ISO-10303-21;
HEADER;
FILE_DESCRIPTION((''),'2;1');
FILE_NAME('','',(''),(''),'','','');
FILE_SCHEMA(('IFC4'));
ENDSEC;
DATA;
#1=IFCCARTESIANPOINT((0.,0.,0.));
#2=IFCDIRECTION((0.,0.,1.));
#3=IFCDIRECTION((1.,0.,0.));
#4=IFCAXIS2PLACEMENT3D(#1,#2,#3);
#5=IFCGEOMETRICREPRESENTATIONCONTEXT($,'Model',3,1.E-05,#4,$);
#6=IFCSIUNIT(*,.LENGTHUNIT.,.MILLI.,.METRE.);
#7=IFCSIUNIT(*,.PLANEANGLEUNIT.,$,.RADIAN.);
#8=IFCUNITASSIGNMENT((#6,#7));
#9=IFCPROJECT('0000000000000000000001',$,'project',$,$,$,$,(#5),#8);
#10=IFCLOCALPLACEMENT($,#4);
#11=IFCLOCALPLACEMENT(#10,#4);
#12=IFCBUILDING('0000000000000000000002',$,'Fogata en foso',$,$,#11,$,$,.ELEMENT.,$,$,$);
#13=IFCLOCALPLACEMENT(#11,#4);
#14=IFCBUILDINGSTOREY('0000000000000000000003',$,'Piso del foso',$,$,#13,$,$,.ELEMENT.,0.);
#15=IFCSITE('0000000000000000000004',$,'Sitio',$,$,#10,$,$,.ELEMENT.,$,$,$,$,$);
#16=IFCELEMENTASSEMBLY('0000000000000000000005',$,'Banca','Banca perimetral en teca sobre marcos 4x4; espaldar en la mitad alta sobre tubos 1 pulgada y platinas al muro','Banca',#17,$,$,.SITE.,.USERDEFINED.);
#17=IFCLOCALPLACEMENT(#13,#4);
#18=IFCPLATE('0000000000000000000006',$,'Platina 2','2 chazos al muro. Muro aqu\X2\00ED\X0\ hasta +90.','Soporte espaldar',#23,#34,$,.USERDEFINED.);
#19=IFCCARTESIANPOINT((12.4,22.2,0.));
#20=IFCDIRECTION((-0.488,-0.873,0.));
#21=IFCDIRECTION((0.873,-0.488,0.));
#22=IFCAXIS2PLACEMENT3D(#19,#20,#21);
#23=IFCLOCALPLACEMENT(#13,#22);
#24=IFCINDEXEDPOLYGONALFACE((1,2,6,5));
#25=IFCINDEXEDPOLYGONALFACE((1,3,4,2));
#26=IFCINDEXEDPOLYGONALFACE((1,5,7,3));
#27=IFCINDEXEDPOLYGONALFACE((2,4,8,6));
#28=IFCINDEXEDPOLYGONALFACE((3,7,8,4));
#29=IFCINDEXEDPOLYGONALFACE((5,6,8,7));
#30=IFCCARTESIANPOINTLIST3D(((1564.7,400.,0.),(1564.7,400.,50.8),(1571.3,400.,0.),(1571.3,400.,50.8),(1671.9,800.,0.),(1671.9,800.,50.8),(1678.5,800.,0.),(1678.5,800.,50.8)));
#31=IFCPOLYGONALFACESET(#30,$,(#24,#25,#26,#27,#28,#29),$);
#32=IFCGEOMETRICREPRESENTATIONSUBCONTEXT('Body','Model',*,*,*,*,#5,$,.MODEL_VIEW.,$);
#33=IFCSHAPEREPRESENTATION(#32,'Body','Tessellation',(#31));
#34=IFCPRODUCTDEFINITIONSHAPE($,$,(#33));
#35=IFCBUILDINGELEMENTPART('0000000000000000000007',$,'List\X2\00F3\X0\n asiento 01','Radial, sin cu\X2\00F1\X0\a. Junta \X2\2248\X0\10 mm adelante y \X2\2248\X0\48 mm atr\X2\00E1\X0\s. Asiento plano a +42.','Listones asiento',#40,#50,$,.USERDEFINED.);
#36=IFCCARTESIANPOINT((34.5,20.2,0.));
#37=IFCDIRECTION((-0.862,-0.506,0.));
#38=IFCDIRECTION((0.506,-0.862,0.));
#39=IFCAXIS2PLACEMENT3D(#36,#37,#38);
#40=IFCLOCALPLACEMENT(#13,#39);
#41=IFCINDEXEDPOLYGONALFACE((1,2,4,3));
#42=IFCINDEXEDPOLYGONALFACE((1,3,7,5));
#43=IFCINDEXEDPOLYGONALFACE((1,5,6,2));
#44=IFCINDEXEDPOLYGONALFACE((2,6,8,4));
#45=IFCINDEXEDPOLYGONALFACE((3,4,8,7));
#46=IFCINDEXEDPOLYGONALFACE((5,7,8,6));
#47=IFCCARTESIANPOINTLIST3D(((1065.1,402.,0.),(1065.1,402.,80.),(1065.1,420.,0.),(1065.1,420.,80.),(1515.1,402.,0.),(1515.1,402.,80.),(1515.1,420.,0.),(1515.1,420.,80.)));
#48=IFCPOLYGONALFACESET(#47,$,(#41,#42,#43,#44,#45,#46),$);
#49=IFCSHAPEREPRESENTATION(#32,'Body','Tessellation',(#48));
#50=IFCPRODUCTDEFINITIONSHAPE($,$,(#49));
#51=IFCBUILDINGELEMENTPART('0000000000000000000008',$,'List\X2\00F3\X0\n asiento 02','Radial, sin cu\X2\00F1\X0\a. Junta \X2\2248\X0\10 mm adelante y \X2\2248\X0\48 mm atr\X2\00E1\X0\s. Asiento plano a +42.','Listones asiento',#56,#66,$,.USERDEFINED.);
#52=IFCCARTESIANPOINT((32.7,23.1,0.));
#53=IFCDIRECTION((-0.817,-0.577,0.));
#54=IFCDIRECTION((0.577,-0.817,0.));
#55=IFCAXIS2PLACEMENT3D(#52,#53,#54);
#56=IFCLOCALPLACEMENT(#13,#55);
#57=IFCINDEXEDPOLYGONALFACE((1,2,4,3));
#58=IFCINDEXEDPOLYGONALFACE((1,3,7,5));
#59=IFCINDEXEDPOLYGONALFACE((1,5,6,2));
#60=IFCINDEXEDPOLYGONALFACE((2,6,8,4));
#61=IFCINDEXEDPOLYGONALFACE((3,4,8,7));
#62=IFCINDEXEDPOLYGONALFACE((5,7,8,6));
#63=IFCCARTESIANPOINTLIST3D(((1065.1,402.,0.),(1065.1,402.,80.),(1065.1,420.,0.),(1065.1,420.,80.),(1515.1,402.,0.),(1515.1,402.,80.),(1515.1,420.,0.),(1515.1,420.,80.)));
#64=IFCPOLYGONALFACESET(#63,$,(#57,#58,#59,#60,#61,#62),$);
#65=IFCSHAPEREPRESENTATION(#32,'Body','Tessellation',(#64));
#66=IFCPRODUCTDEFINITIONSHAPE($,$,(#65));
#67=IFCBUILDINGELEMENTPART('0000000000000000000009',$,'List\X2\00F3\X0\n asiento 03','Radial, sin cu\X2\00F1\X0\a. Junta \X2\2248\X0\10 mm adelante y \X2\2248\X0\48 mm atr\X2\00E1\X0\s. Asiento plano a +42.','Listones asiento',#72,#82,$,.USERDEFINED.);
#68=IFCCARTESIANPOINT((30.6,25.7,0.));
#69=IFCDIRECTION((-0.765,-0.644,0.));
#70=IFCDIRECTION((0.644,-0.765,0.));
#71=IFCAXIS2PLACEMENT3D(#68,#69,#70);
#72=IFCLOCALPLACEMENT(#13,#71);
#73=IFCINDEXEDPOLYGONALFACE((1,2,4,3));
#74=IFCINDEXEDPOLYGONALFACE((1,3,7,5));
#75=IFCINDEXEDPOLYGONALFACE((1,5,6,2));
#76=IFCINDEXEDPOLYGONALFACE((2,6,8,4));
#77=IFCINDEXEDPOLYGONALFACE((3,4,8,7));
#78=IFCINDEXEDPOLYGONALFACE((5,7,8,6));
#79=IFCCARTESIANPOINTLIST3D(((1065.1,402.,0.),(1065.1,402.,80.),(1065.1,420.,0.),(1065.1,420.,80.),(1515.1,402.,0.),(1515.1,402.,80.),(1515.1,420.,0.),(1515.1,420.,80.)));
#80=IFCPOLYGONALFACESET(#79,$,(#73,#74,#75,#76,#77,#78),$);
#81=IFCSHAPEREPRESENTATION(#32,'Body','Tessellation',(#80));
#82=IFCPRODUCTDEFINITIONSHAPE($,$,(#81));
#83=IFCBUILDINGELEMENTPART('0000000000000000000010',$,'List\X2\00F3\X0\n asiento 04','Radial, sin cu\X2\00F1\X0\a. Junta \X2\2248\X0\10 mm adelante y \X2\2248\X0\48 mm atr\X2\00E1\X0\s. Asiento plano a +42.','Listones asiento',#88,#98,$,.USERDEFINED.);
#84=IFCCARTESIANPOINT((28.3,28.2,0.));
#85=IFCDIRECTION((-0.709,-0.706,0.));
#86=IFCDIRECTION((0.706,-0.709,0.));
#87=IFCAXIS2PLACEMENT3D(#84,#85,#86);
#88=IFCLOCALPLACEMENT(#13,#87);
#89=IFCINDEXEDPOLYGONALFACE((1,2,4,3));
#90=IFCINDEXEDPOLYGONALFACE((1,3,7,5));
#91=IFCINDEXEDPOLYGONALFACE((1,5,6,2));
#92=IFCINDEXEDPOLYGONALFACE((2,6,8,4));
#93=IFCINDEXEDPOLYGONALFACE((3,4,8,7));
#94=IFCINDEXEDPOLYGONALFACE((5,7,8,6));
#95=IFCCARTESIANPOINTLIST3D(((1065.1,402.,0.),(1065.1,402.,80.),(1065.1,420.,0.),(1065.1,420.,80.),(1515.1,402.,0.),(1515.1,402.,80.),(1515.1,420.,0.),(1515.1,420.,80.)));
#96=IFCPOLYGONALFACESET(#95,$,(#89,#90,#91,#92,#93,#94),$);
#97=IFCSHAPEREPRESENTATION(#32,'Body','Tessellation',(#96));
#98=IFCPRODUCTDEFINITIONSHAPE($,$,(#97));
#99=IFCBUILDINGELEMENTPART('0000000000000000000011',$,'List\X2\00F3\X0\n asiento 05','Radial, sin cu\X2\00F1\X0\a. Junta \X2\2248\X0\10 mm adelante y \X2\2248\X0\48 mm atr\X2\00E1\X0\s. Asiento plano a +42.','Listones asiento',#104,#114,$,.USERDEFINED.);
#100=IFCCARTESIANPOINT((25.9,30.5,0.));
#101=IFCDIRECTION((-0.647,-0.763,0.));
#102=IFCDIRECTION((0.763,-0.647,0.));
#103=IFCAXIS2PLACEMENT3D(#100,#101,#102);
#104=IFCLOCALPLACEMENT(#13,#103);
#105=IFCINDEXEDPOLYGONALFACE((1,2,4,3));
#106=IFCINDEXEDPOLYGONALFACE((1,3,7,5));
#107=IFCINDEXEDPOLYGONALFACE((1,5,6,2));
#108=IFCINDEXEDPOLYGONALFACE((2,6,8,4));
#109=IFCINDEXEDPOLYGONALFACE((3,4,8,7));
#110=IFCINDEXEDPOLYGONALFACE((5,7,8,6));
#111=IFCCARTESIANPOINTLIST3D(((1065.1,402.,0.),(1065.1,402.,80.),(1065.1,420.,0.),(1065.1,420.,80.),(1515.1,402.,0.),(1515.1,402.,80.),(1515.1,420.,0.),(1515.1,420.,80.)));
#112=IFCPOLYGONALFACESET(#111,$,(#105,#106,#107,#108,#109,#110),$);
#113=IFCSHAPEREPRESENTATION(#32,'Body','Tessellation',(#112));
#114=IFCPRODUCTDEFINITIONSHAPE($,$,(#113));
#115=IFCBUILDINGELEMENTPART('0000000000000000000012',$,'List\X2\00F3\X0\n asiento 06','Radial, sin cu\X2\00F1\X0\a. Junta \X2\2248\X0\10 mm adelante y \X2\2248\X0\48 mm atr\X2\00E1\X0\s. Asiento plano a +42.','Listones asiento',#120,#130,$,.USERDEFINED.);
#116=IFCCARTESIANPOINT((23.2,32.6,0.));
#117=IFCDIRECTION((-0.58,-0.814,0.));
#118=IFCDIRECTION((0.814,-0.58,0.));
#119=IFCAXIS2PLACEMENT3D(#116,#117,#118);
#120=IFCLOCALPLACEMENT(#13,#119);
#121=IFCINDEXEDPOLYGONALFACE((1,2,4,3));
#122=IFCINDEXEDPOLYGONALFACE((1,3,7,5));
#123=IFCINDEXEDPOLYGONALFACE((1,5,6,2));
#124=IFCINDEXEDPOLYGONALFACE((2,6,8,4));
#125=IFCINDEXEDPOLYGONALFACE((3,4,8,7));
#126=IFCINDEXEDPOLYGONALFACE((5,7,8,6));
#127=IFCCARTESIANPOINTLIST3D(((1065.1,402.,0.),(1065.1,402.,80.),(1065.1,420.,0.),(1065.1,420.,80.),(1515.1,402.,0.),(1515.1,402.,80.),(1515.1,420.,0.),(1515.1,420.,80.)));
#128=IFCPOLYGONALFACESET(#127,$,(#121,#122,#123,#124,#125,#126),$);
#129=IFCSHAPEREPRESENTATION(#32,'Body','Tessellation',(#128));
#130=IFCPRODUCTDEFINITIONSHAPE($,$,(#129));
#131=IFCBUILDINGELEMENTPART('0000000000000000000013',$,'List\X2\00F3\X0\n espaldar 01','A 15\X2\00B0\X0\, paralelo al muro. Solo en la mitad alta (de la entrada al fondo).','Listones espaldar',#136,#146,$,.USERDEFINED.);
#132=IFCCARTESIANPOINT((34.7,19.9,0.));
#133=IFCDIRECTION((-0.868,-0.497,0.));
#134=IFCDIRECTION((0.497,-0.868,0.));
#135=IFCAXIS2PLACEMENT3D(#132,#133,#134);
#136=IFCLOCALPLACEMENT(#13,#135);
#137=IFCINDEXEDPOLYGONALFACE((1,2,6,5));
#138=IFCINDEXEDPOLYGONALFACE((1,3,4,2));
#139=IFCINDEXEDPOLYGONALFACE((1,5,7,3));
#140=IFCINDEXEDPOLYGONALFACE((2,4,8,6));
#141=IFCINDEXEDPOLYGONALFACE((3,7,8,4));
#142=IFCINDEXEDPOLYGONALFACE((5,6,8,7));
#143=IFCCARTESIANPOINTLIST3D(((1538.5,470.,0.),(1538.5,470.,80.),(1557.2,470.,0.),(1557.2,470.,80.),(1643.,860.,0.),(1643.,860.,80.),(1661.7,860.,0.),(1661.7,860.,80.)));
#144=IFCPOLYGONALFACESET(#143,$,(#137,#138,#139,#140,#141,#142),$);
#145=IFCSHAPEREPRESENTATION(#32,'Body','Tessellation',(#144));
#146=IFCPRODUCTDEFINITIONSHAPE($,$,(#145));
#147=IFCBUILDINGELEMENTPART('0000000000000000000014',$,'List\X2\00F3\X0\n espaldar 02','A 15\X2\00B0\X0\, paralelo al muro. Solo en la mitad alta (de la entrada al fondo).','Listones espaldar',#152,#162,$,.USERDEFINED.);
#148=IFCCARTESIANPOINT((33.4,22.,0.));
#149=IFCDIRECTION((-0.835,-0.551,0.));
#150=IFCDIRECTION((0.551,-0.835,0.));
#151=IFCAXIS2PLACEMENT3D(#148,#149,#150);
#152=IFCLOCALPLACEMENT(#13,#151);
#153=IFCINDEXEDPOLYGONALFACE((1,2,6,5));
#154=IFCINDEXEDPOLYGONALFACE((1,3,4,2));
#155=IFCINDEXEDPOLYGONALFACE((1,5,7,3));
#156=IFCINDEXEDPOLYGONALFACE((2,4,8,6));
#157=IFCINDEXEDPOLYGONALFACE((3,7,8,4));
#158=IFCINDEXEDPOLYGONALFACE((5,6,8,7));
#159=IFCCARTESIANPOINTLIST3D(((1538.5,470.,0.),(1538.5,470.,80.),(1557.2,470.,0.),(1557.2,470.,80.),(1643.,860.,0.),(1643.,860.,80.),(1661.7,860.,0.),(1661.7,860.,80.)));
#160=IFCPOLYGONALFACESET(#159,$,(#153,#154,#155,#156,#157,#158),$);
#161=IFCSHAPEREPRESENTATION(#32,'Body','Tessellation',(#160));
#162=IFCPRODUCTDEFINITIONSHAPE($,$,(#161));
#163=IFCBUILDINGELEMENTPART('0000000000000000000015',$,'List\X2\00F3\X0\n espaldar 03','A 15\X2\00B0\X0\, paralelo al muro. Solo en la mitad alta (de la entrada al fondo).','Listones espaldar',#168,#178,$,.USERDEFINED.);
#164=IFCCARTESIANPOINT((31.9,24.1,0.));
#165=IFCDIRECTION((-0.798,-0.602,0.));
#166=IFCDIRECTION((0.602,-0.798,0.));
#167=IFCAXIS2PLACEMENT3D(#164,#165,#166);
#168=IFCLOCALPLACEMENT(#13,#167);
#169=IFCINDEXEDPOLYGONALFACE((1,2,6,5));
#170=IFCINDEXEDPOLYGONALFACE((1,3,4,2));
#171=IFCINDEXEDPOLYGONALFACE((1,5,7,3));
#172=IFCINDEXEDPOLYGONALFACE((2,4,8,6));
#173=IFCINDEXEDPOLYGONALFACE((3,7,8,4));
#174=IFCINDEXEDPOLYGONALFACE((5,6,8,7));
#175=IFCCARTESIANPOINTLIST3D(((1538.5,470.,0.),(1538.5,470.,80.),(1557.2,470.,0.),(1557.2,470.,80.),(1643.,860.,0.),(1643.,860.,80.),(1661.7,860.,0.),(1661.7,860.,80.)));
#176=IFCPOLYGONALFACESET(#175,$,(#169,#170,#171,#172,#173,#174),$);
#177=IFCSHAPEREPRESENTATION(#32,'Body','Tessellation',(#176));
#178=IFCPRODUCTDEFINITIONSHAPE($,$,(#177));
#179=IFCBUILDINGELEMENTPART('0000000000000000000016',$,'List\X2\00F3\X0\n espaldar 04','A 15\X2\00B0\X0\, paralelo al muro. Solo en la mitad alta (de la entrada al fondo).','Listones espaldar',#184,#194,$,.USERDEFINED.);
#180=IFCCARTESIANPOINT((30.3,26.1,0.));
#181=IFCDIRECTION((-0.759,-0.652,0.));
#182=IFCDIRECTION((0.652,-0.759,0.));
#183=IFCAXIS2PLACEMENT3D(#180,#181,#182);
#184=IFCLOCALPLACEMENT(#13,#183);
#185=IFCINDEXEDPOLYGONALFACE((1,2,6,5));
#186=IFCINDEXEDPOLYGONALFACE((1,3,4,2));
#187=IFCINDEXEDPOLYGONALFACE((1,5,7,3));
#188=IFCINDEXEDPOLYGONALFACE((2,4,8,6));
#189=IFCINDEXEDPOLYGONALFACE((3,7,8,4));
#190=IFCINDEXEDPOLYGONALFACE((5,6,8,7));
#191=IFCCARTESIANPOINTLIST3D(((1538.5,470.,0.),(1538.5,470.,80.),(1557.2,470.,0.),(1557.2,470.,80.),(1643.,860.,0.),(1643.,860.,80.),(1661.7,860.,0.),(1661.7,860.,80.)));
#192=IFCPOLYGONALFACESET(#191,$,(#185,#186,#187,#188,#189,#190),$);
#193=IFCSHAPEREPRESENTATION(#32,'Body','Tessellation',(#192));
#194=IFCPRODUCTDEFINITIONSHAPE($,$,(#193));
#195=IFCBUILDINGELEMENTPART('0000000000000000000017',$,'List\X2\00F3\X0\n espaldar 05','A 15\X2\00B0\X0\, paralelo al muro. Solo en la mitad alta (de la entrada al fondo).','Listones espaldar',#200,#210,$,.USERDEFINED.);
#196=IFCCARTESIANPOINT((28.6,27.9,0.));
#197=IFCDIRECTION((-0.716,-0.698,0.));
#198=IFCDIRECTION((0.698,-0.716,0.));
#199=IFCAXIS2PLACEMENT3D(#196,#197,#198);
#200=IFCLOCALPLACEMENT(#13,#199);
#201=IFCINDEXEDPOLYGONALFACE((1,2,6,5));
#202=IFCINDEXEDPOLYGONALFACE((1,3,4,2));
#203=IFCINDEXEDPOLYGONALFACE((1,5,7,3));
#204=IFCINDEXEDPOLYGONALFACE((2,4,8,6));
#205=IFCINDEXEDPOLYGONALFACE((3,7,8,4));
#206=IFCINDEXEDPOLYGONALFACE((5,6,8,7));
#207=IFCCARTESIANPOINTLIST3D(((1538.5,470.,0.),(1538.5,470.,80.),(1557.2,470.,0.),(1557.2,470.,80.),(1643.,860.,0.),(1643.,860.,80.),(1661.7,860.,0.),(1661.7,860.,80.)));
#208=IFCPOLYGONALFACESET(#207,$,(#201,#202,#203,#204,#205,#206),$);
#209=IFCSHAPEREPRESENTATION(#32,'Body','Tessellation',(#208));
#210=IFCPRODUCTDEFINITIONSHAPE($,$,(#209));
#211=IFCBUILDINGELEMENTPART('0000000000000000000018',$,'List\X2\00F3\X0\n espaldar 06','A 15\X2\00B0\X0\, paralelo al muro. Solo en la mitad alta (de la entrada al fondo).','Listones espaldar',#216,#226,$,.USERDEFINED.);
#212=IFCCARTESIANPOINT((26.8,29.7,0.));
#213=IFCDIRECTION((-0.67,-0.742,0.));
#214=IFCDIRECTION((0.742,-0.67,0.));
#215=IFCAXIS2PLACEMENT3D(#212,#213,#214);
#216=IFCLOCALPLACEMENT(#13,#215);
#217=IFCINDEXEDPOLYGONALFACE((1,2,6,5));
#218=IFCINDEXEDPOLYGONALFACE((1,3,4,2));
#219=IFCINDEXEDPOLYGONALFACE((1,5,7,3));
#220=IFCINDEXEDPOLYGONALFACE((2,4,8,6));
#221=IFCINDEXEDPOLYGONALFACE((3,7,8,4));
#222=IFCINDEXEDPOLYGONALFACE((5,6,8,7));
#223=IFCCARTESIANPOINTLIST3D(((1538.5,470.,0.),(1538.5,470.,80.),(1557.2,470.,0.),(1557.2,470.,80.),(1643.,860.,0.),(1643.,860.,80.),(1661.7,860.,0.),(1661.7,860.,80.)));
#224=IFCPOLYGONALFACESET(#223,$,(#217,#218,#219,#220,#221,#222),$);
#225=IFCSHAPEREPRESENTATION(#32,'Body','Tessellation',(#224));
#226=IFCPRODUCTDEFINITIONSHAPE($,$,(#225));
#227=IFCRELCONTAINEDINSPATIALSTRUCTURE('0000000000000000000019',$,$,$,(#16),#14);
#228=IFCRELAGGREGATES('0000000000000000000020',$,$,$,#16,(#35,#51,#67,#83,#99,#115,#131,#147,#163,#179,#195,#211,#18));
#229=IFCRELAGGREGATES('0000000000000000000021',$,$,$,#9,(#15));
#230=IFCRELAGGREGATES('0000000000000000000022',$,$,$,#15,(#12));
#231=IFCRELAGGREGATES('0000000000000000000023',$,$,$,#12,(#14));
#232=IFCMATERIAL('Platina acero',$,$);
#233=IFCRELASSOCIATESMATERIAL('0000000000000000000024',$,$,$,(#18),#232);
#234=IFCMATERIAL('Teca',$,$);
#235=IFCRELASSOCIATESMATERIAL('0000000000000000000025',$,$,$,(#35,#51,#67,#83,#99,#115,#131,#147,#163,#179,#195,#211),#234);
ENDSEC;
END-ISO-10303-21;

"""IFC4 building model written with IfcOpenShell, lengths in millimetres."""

from ifc_helpers import new_model, si_unit, frame, origin_with_axes, place, context, subcontext, project, spatial, polyline, outline, extrude, material, element, aggregate, save


model = new_model("IFC4")

# Units and contexts
model_context = context("Model", 3, precision=1e-05, world=origin_with_axes())
body_context = subcontext(model_context, "Body", "Model", "MODEL_VIEW")
ifc_project = project(units=[si_unit("LENGTHUNIT", "METRE", prefix="MILLI"), si_unit("PLANEANGLEUNIT", "RADIAN")], contexts=[model_context])

# Site, building, storey
site_placement = place(None, origin_with_axes())
site = spatial("IfcSite", under=ifc_project, at=site_placement, Name="Sitio", CompositionType="ELEMENT")
building_placement = place(site_placement, origin_with_axes())
building = spatial("IfcBuilding", under=site, at=building_placement, Name="Fogata en foso", CompositionType="ELEMENT")
storey_placement = place(building_placement, origin_with_axes())
storey = spatial("IfcBuildingStorey", under=building, at=storey_placement, Name="Piso del foso", CompositionType="ELEMENT", Elevation=0.0)

# Element assembly
assembly_1_placement = place(storey_placement, origin_with_axes())
assembly_1 = element("IfcElementAssembly", 1, at=assembly_1_placement, inside=storey, Name="Banca", Description="Banca perimetral en teca sobre marcos 4x4; espaldar en la mitad alta sobre tubos 1 pulgada y platinas al muro", ObjectType="Banca", AssemblyPlace="SITE", PredefinedType="USERDEFINED")

# Plate
ifc_material_1 = material(Name="Platina acero")
plate_1_placement = place(storey_placement, frame((12.4, 22.2, 0.0), z_axis=(-0.488, -0.873, 0.0), x_axis=(0.873, -0.488, 0.0)))
plate_1 = element("IfcPlate", 2, at=plate_1_placement, material=ifc_material_1, Name="Platina 2", Description="2 chazos al muro. Muro aquí hasta +90.", ObjectType="Soporte espaldar", PredefinedType="USERDEFINED", context=body_context, shape_type="SweptSolid", body=[
    extrude(outline(polyline([(1564.7, 400.0), (1571.3, 400.0), (1678.5, 800.0), (1671.9, 800.0), (1564.7, 400.0)])), origin_with_axes(), (0.0, 0.0, 1.0), 50.8),
])

# Building element parts
ifc_material_2 = material(Name="Teca")
building_element_part_1_placement = place(storey_placement, frame((34.5, 20.2, 0.0), z_axis=(-0.862, -0.506, 0.0), x_axis=(0.506, -0.862, 0.0)))
building_element_part_1 = element("IfcBuildingElementPart", 3, at=building_element_part_1_placement, material=ifc_material_2, Name="Listón asiento 01", Description="Radial, sin cuña. Junta ≈10 mm adelante y ≈48 mm atrás. Asiento plano a +42.", ObjectType="Listones asiento", PredefinedType="USERDEFINED", context=body_context, shape_type="SweptSolid", body=[
    extrude(outline(polyline([(1065.1, 402.0), (1515.1, 402.0), (1515.1, 420.0), (1065.1, 420.0), (1065.1, 402.0)])), origin_with_axes(), (0.0, 0.0, 1.0), 80.0),
])
building_element_part_2_placement = place(storey_placement, frame((32.7, 23.1, 0.0), z_axis=(-0.817, -0.577, 0.0), x_axis=(0.577, -0.817, 0.0)))
building_element_part_2 = element("IfcBuildingElementPart", 4, at=building_element_part_2_placement, material=ifc_material_2, Name="Listón asiento 02", Description="Radial, sin cuña. Junta ≈10 mm adelante y ≈48 mm atrás. Asiento plano a +42.", ObjectType="Listones asiento", PredefinedType="USERDEFINED", context=body_context, shape_type="SweptSolid", body=[
    extrude(outline(polyline([(1065.1, 402.0), (1515.1, 402.0), (1515.1, 420.0), (1065.1, 420.0), (1065.1, 402.0)])), origin_with_axes(), (0.0, 0.0, 1.0), 80.0),
])
building_element_part_3_placement = place(storey_placement, frame((30.6, 25.7, 0.0), z_axis=(-0.765, -0.644, 0.0), x_axis=(0.644, -0.765, 0.0)))
building_element_part_3 = element("IfcBuildingElementPart", 5, at=building_element_part_3_placement, material=ifc_material_2, Name="Listón asiento 03", Description="Radial, sin cuña. Junta ≈10 mm adelante y ≈48 mm atrás. Asiento plano a +42.", ObjectType="Listones asiento", PredefinedType="USERDEFINED", context=body_context, shape_type="SweptSolid", body=[
    extrude(outline(polyline([(1065.1, 402.0), (1515.1, 402.0), (1515.1, 420.0), (1065.1, 420.0), (1065.1, 402.0)])), origin_with_axes(), (0.0, 0.0, 1.0), 80.0),
])
building_element_part_4_placement = place(storey_placement, frame((28.3, 28.2, 0.0), z_axis=(-0.709, -0.706, 0.0), x_axis=(0.706, -0.709, 0.0)))
building_element_part_4 = element("IfcBuildingElementPart", 6, at=building_element_part_4_placement, material=ifc_material_2, Name="Listón asiento 04", Description="Radial, sin cuña. Junta ≈10 mm adelante y ≈48 mm atrás. Asiento plano a +42.", ObjectType="Listones asiento", PredefinedType="USERDEFINED", context=body_context, shape_type="SweptSolid", body=[
    extrude(outline(polyline([(1065.1, 402.0), (1515.1, 402.0), (1515.1, 420.0), (1065.1, 420.0), (1065.1, 402.0)])), origin_with_axes(), (0.0, 0.0, 1.0), 80.0),
])
building_element_part_5_placement = place(storey_placement, frame((25.9, 30.5, 0.0), z_axis=(-0.647, -0.763, 0.0), x_axis=(0.763, -0.647, 0.0)))
building_element_part_5 = element("IfcBuildingElementPart", 7, at=building_element_part_5_placement, material=ifc_material_2, Name="Listón asiento 05", Description="Radial, sin cuña. Junta ≈10 mm adelante y ≈48 mm atrás. Asiento plano a +42.", ObjectType="Listones asiento", PredefinedType="USERDEFINED", context=body_context, shape_type="SweptSolid", body=[
    extrude(outline(polyline([(1065.1, 402.0), (1515.1, 402.0), (1515.1, 420.0), (1065.1, 420.0), (1065.1, 402.0)])), origin_with_axes(), (0.0, 0.0, 1.0), 80.0),
])
building_element_part_6_placement = place(storey_placement, frame((23.2, 32.6, 0.0), z_axis=(-0.58, -0.814, 0.0), x_axis=(0.814, -0.58, 0.0)))
building_element_part_6 = element("IfcBuildingElementPart", 8, at=building_element_part_6_placement, material=ifc_material_2, Name="Listón asiento 06", Description="Radial, sin cuña. Junta ≈10 mm adelante y ≈48 mm atrás. Asiento plano a +42.", ObjectType="Listones asiento", PredefinedType="USERDEFINED", context=body_context, shape_type="SweptSolid", body=[
    extrude(outline(polyline([(1065.1, 402.0), (1515.1, 402.0), (1515.1, 420.0), (1065.1, 420.0), (1065.1, 402.0)])), origin_with_axes(), (0.0, 0.0, 1.0), 80.0),
])

# Building element parts
building_element_part_7_placement = place(storey_placement, frame((34.7, 19.9, 0.0), z_axis=(-0.868, -0.497, 0.0), x_axis=(0.497, -0.868, 0.0)))
building_element_part_7 = element("IfcBuildingElementPart", 9, at=building_element_part_7_placement, material=ifc_material_2, Name="Listón espaldar 01", Description="A 15°, paralelo al muro. Solo en la mitad alta (de la entrada al fondo).", ObjectType="Listones espaldar", PredefinedType="USERDEFINED", context=body_context, shape_type="SweptSolid", body=[
    extrude(outline(polyline([(1538.5, 470.0), (1557.2, 470.0), (1661.7, 860.0), (1643.0, 860.0), (1538.5, 470.0)])), origin_with_axes(), (0.0, 0.0, 1.0), 80.0),
])
building_element_part_8_placement = place(storey_placement, frame((33.4, 22.0, 0.0), z_axis=(-0.835, -0.551, 0.0), x_axis=(0.551, -0.835, 0.0)))
building_element_part_8 = element("IfcBuildingElementPart", 10, at=building_element_part_8_placement, material=ifc_material_2, Name="Listón espaldar 02", Description="A 15°, paralelo al muro. Solo en la mitad alta (de la entrada al fondo).", ObjectType="Listones espaldar", PredefinedType="USERDEFINED", context=body_context, shape_type="SweptSolid", body=[
    extrude(outline(polyline([(1538.5, 470.0), (1557.2, 470.0), (1661.7, 860.0), (1643.0, 860.0), (1538.5, 470.0)])), origin_with_axes(), (0.0, 0.0, 1.0), 80.0),
])
building_element_part_9_placement = place(storey_placement, frame((31.9, 24.1, 0.0), z_axis=(-0.798, -0.602, 0.0), x_axis=(0.602, -0.798, 0.0)))
building_element_part_9 = element("IfcBuildingElementPart", 11, at=building_element_part_9_placement, material=ifc_material_2, Name="Listón espaldar 03", Description="A 15°, paralelo al muro. Solo en la mitad alta (de la entrada al fondo).", ObjectType="Listones espaldar", PredefinedType="USERDEFINED", context=body_context, shape_type="SweptSolid", body=[
    extrude(outline(polyline([(1538.5, 470.0), (1557.2, 470.0), (1661.7, 860.0), (1643.0, 860.0), (1538.5, 470.0)])), origin_with_axes(), (0.0, 0.0, 1.0), 80.0),
])
building_element_part_10_placement = place(storey_placement, frame((30.3, 26.1, 0.0), z_axis=(-0.759, -0.652, 0.0), x_axis=(0.652, -0.759, 0.0)))
building_element_part_10 = element("IfcBuildingElementPart", 12, at=building_element_part_10_placement, material=ifc_material_2, Name="Listón espaldar 04", Description="A 15°, paralelo al muro. Solo en la mitad alta (de la entrada al fondo).", ObjectType="Listones espaldar", PredefinedType="USERDEFINED", context=body_context, shape_type="SweptSolid", body=[
    extrude(outline(polyline([(1538.5, 470.0), (1557.2, 470.0), (1661.7, 860.0), (1643.0, 860.0), (1538.5, 470.0)])), origin_with_axes(), (0.0, 0.0, 1.0), 80.0),
])
building_element_part_11_placement = place(storey_placement, frame((28.6, 27.9, 0.0), z_axis=(-0.716, -0.698, 0.0), x_axis=(0.698, -0.716, 0.0)))
building_element_part_11 = element("IfcBuildingElementPart", 13, at=building_element_part_11_placement, material=ifc_material_2, Name="Listón espaldar 05", Description="A 15°, paralelo al muro. Solo en la mitad alta (de la entrada al fondo).", ObjectType="Listones espaldar", PredefinedType="USERDEFINED", context=body_context, shape_type="SweptSolid", body=[
    extrude(outline(polyline([(1538.5, 470.0), (1557.2, 470.0), (1661.7, 860.0), (1643.0, 860.0), (1538.5, 470.0)])), origin_with_axes(), (0.0, 0.0, 1.0), 80.0),
])
building_element_part_12_placement = place(storey_placement, frame((26.8, 29.7, 0.0), z_axis=(-0.67, -0.742, 0.0), x_axis=(0.742, -0.67, 0.0)))
building_element_part_12 = element("IfcBuildingElementPart", 14, at=building_element_part_12_placement, material=ifc_material_2, Name="Listón espaldar 06", Description="A 15°, paralelo al muro. Solo en la mitad alta (de la entrada al fondo).", ObjectType="Listones espaldar", PredefinedType="USERDEFINED", context=body_context, shape_type="SweptSolid", body=[
    extrude(outline(polyline([(1538.5, 470.0), (1557.2, 470.0), (1661.7, 860.0), (1643.0, 860.0), (1538.5, 470.0)])), origin_with_axes(), (0.0, 0.0, 1.0), 80.0),
])
aggregate(assembly_1, [building_element_part_1, building_element_part_2, building_element_part_3, building_element_part_4, building_element_part_5, building_element_part_6, building_element_part_7, building_element_part_8, building_element_part_9, building_element_part_10, building_element_part_11, building_element_part_12, plate_1])

save(model, "model.ifc")
